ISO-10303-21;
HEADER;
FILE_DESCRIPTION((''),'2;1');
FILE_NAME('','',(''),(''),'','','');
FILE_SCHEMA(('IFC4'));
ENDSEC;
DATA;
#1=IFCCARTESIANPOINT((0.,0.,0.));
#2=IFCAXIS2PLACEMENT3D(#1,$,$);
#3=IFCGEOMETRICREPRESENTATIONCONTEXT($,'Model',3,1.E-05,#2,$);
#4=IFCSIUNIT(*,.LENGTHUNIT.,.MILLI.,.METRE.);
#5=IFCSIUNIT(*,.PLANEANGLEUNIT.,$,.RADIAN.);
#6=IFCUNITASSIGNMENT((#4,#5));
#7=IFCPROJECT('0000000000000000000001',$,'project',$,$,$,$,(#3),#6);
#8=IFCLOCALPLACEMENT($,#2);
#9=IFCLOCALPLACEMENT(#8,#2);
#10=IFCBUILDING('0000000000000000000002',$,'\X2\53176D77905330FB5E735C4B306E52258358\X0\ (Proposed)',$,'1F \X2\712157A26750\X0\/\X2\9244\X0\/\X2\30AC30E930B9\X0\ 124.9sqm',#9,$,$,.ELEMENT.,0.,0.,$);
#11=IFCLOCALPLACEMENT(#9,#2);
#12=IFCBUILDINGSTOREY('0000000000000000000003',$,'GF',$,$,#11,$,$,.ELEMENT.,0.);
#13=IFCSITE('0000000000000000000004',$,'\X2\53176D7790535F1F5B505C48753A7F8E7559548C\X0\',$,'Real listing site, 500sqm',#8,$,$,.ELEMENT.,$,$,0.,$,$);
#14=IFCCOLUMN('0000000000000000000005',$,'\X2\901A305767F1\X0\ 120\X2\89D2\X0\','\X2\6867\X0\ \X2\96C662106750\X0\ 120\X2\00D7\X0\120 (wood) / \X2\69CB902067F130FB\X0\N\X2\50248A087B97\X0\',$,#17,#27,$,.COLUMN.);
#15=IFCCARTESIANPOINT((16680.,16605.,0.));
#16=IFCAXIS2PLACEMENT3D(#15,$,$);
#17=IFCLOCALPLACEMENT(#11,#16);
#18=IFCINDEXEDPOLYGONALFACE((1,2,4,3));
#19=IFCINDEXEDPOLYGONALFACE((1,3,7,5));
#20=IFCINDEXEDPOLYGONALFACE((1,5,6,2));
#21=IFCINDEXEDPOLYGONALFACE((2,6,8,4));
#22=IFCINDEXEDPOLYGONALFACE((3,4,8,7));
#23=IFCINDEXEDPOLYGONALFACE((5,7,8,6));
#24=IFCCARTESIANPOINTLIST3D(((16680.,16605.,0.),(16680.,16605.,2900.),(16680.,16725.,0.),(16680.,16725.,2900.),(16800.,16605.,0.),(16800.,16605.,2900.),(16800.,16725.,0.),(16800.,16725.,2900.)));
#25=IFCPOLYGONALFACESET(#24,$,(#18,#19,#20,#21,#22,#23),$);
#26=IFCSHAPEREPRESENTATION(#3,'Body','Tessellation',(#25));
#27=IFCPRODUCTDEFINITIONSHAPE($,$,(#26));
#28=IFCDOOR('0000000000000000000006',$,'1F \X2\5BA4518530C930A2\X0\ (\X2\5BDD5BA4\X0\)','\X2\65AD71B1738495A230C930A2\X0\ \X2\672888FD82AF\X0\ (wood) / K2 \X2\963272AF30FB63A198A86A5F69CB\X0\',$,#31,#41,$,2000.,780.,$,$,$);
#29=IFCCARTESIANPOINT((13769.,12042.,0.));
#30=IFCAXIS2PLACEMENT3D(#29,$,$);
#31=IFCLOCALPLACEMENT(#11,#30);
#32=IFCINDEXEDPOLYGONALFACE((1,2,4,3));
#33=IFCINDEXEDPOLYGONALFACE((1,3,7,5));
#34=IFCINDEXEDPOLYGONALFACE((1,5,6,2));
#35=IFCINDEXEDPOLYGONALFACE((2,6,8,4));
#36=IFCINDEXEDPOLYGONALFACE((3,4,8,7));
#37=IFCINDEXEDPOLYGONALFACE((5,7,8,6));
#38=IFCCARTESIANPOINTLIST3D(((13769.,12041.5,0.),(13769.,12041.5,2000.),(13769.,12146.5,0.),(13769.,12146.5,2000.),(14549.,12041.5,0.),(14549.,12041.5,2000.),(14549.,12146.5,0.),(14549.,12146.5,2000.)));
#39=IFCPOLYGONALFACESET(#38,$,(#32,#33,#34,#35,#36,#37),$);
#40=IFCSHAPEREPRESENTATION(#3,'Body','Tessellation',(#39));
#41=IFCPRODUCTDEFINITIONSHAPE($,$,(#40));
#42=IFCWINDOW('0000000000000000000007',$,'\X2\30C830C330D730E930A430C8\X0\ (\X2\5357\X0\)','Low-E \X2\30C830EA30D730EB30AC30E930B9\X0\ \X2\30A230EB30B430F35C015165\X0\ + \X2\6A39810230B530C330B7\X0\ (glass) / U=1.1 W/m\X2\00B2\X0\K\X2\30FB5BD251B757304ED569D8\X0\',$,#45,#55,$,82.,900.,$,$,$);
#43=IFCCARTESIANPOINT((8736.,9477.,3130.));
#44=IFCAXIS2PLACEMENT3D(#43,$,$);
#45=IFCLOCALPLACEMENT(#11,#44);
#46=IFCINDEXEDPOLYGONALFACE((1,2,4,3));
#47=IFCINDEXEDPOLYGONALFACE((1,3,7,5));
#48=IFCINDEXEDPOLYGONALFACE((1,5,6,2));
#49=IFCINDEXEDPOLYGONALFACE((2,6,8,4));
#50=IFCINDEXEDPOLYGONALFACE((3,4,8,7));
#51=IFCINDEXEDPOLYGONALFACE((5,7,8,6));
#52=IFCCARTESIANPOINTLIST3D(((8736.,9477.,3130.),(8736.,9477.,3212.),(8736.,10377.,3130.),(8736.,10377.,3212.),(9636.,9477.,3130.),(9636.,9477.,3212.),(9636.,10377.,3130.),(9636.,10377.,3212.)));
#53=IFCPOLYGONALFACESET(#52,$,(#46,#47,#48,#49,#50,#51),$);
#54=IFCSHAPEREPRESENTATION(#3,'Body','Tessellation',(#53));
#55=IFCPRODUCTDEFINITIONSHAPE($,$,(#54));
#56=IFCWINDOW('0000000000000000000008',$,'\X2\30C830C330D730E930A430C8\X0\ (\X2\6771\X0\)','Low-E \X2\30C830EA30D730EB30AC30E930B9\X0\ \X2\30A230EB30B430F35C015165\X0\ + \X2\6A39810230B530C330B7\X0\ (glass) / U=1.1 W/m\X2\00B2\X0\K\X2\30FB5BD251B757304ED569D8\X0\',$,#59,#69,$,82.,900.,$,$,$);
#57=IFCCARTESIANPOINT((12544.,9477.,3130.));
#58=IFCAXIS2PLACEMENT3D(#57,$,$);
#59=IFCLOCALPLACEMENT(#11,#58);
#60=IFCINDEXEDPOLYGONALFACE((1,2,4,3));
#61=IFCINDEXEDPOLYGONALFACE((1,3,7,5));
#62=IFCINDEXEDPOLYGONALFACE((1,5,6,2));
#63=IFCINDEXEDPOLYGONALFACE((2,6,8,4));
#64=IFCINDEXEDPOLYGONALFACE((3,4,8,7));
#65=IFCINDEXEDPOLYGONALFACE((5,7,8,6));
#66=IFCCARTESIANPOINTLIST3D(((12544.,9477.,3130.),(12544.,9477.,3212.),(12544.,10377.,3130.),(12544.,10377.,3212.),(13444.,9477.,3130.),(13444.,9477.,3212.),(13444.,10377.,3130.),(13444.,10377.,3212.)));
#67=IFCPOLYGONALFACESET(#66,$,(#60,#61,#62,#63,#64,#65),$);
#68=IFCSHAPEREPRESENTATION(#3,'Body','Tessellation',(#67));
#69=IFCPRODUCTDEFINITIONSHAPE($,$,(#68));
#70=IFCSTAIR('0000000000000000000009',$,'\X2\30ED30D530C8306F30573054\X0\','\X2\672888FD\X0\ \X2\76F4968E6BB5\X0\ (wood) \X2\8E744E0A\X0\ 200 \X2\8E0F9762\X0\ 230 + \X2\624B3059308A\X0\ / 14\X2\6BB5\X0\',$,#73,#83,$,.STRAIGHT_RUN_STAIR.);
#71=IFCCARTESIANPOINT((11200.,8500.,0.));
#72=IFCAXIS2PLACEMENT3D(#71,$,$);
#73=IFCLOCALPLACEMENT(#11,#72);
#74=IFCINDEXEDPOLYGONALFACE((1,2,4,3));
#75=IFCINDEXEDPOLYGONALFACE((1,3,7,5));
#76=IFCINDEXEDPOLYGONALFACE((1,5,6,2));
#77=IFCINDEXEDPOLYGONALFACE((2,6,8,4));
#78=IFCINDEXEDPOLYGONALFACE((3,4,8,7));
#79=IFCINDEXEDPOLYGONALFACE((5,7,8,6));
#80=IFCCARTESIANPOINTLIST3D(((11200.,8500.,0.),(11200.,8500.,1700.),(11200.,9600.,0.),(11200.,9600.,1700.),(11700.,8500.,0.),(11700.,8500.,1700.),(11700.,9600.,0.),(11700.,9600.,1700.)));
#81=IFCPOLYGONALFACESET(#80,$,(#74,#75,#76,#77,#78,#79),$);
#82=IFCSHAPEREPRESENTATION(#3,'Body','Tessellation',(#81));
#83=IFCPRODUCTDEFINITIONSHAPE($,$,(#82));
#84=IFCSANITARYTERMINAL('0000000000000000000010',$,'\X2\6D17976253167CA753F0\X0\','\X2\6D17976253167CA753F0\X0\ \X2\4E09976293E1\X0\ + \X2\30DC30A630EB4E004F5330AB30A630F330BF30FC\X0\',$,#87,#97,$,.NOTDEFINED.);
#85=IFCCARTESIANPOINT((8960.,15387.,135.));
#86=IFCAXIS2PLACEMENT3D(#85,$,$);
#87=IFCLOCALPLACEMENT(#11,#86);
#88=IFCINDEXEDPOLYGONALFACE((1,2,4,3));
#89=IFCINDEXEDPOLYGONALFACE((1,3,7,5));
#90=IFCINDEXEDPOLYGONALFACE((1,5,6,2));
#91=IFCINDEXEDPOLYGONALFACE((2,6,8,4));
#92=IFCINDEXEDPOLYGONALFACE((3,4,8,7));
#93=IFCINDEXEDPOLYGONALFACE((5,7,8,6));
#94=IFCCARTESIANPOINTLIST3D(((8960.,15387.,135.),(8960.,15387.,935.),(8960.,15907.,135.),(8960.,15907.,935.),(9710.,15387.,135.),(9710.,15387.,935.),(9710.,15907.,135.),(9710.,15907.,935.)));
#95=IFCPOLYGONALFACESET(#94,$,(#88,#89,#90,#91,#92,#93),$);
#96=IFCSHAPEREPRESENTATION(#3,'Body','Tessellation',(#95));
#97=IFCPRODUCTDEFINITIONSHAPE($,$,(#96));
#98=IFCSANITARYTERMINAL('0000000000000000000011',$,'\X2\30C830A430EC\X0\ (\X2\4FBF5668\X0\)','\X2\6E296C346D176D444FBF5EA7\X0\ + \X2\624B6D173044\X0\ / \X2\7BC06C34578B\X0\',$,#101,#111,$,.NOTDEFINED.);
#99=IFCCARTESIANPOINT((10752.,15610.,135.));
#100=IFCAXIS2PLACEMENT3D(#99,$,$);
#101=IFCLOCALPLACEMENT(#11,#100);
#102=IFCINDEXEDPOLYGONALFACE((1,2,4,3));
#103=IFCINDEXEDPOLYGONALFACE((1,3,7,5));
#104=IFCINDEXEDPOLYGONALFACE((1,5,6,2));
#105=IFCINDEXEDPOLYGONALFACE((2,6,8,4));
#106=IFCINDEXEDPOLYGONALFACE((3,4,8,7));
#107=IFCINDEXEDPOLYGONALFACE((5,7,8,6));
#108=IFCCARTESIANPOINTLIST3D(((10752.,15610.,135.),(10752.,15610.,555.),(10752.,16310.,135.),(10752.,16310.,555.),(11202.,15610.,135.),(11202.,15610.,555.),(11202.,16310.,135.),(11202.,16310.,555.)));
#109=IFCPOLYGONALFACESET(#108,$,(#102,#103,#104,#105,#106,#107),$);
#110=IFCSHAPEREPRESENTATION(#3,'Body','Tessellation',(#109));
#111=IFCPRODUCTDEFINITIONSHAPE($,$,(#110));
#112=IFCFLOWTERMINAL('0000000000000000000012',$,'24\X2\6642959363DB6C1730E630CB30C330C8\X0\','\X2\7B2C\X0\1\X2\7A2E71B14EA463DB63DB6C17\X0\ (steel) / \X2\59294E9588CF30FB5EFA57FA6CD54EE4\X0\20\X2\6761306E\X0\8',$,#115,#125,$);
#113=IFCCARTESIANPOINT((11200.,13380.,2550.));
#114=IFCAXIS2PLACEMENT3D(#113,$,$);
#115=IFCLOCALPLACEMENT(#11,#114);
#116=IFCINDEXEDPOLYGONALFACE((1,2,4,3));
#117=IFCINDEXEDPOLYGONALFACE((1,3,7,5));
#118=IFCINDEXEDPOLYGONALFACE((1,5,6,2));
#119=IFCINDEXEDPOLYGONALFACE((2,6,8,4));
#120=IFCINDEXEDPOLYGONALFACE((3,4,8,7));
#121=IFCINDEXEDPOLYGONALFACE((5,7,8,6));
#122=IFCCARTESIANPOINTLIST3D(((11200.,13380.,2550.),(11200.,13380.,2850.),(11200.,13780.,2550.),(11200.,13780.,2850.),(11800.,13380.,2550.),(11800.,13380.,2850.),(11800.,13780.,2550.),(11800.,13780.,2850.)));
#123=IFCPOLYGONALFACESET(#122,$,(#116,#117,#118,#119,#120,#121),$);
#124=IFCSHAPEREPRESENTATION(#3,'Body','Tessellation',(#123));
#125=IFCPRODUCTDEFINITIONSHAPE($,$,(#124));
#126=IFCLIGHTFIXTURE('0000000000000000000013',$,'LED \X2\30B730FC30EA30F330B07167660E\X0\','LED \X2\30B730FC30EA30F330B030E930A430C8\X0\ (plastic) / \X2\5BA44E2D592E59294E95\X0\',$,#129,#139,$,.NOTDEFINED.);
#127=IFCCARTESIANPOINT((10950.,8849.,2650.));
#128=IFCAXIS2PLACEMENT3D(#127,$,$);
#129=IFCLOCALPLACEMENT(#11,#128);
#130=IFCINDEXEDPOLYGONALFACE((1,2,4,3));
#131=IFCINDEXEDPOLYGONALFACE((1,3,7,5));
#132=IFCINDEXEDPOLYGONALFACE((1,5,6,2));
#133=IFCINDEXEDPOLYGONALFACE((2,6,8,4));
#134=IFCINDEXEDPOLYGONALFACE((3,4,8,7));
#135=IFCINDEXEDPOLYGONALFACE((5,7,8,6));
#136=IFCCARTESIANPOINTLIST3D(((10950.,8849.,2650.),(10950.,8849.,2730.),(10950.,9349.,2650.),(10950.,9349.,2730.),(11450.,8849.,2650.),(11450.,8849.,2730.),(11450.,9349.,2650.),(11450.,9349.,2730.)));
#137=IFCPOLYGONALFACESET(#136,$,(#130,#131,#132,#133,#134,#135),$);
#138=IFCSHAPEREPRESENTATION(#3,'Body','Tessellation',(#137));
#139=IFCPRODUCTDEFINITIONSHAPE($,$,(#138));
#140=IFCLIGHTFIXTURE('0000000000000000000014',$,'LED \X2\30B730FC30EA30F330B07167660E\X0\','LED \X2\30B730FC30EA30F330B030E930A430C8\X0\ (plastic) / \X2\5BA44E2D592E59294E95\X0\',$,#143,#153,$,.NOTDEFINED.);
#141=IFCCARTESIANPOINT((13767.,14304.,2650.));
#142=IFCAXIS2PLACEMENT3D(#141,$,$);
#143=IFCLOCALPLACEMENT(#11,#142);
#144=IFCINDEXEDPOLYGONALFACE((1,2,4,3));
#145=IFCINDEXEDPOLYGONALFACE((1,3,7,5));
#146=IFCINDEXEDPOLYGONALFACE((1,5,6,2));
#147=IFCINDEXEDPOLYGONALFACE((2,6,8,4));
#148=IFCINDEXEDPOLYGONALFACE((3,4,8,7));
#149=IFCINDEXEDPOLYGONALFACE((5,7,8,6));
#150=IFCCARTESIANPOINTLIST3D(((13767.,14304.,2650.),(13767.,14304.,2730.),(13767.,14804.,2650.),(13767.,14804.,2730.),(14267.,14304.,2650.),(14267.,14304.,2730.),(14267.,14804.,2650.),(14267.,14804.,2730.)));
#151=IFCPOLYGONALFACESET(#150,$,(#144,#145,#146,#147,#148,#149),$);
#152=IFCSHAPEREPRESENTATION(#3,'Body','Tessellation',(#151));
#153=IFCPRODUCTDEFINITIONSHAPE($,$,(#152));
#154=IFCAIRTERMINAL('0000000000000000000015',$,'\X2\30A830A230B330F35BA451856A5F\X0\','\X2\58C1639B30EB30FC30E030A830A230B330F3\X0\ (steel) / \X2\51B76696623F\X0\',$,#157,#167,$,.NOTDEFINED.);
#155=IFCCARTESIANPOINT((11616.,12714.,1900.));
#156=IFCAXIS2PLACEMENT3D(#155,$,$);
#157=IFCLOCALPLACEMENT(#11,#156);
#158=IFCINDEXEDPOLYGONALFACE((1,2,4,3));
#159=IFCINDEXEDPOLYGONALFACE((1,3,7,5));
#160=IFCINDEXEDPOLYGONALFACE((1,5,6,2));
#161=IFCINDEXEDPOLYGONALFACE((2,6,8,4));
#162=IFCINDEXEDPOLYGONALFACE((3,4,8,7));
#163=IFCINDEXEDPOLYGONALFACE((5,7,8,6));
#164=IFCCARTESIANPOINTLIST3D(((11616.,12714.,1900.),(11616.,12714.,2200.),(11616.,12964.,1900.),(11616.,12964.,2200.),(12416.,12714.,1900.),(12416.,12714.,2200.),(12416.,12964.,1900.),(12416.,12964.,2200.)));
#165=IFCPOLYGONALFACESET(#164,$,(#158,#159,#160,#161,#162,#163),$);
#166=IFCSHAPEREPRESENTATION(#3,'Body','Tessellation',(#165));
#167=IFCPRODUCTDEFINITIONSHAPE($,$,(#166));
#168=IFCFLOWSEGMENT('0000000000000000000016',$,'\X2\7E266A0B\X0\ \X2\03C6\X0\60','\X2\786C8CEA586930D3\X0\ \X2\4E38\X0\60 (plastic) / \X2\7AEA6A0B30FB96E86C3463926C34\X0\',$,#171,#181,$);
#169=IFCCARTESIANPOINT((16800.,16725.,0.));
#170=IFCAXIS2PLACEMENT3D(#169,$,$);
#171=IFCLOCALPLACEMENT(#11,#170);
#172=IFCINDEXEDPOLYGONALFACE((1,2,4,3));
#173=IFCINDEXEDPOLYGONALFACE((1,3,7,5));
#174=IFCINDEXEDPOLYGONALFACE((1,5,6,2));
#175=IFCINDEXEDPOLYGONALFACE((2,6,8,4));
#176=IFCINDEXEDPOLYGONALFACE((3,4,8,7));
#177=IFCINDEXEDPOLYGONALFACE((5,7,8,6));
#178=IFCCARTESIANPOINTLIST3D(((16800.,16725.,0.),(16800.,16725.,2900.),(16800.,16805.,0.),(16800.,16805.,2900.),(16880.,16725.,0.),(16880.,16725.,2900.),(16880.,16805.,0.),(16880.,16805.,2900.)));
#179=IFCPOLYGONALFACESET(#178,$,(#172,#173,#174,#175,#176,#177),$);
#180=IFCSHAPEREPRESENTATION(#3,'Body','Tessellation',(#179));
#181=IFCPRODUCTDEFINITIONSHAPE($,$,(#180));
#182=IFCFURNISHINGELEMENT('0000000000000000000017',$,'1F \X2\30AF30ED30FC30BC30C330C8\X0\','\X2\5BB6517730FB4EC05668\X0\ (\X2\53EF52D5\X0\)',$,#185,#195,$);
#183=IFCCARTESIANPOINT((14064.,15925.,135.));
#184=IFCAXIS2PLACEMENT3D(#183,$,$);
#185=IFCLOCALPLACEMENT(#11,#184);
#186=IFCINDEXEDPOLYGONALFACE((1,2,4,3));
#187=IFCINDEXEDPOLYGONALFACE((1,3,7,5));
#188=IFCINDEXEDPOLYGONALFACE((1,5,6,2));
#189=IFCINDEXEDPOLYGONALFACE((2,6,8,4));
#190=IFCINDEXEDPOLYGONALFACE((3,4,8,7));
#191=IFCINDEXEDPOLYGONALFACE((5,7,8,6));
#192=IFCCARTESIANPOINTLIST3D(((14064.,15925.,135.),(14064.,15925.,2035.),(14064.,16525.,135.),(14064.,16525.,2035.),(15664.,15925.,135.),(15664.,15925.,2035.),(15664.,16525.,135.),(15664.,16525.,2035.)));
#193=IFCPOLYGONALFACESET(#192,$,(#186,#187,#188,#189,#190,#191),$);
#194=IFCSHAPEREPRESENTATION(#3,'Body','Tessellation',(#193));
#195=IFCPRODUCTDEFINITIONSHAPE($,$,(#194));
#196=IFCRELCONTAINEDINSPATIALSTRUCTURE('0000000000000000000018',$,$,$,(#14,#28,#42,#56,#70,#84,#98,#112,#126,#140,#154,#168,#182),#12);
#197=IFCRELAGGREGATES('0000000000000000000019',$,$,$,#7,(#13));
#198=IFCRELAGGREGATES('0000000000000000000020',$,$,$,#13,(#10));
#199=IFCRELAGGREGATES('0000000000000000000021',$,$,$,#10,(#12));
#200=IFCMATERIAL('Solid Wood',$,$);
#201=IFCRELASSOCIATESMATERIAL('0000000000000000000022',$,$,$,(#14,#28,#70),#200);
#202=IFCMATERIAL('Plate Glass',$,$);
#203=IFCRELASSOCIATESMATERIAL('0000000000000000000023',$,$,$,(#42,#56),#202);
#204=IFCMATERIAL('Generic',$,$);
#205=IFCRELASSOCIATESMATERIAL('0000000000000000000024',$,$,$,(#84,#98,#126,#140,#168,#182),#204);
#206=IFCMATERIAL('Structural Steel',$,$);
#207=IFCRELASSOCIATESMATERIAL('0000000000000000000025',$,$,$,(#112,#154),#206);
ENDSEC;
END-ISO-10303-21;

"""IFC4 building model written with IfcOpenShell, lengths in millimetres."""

from ifc_helpers import new_model, si_unit, frame, frame_2d, origin, place, context, project, spatial, rectangle, extrude, material, element, save


model = new_model("IFC4")

# Units and contexts
model_context = context("Model", 3, precision=1e-05, world=origin())
ifc_project = project(units=[si_unit("LENGTHUNIT", "METRE", prefix="MILLI"), si_unit("PLANEANGLEUNIT", "RADIAN")], contexts=[model_context])

# Site, building, storey
site_placement = place(None, origin())
site = spatial("IfcSite", under=ifc_project, at=site_placement, Name="北海道弟子屈町美留和", ObjectType="Real listing site, 500sqm", CompositionType="ELEMENT", RefElevation=0.0)
building_placement = place(site_placement, origin())
building = spatial("IfcBuilding", under=site, at=building_placement, Name="北海道・平屋の別荘 (Proposed)", ObjectType="1F 無垢材/鉄/ガラス 124.9sqm", CompositionType="ELEMENT", ElevationOfRefHeight=0.0, ElevationOfTerrain=0.0)
storey_placement = place(building_placement, origin())
storey = spatial("IfcBuildingStorey", under=building, at=storey_placement, Name="GF", CompositionType="ELEMENT", Elevation=0.0)

# Column
ifc_material_1 = material(Name="Solid Wood")
column_1_placement = place(storey_placement, frame((16680.0, 16605.0, 0.0)))
element("IfcColumn", 1, at=column_1_placement, inside=storey, material=ifc_material_1, Name="通し柱 120角", Description="桧 集成材 120×120 (wood) / 構造柱・N値計算", PredefinedType="COLUMN", context=model_context, shape_type="SweptSolid", body=[
    extrude(rectangle(XDim=120.0, YDim=120.0, at=frame_2d((60.0, 60.0))), frame((16680.0, 16605.0, 0.0)), (0.0, 0.0, 1.0), 2900.0),
])

# Door
door_placement = place(storey_placement, frame((13769.0, 12042.0, 0.0)))
element("IfcDoor", 2, at=door_placement, inside=storey, material=ifc_material_1, Name="1F 室内ドア (寝室)", Description="断熱玄関ドア 木製芯 (wood) / K2 防犯・採風機構", OverallHeight=2000.0, OverallWidth=780.0, context=model_context, shape_type="SweptSolid", body=[
    extrude(rectangle(XDim=780.0, YDim=105.0, at=frame_2d((390.0, 52.0))), frame((13769.0, 12042.0, 0.0)), (0.0, 0.0, 1.0), 2000.0),
])

# Windows
ifc_material_2 = material(Name="Plate Glass")
window_1_placement = place(storey_placement, frame((8736.0, 9477.0, 3130.0)))
element("IfcWindow", 3, at=window_1_placement, inside=storey, material=ifc_material_2, Name="トップライト (南)", Description="Low-E トリプルガラス アルゴン封入 + 樹脂サッシ (glass) / U=1.1 W/m²K・寒冷地仕様", OverallHeight=82.0, OverallWidth=900.0, context=model_context, shape_type="SweptSolid", body=[
    extrude(rectangle(XDim=900.0, YDim=900.0, at=frame_2d((450.0, 450.0))), frame((8736.0, 9477.0, 3130.0)), (0.0, 0.0, 1.0), 82.0),
])
window_2_placement = place(storey_placement, frame((12544.0, 9477.0, 3130.0)))
element("IfcWindow", 4, at=window_2_placement, inside=storey, material=ifc_material_2, Name="トップライト (東)", Description="Low-E トリプルガラス アルゴン封入 + 樹脂サッシ (glass) / U=1.1 W/m²K・寒冷地仕様", OverallHeight=82.0, OverallWidth=900.0, context=model_context, shape_type="SweptSolid", body=[
    extrude(rectangle(XDim=900.0, YDim=900.0, at=frame_2d((450.0, 450.0))), frame((12544.0, 9477.0, 3130.0)), (0.0, 0.0, 1.0), 82.0),
])

# Stair
stair_placement = place(storey_placement, frame((11200.0, 8500.0, 0.0)))
element("IfcStair", 5, at=stair_placement, inside=storey, material=ifc_material_1, Name="ロフトはしご", Description="木製 直階段 (wood) 蹴上 200 踏面 230 + 手すり / 14段", PredefinedType="STRAIGHT_RUN_STAIR", context=model_context, shape_type="SweptSolid", body=[
    extrude(rectangle(XDim=500.0, YDim=1100.0, at=frame_2d((250.0, 550.0))), frame((11200.0, 8500.0, 0.0)), (0.0, 0.0, 1.0), 1700.0),
])

# Sanitary terminals
ifc_material_3 = material(Name="Generic")
sanitary_terminal_1_placement = place(storey_placement, frame((8960.0, 15387.0, 135.0)))
element("IfcSanitaryTerminal", 6, at=sanitary_terminal_1_placement, inside=storey, material=ifc_material_3, Name="洗面化粧台", Description="洗面化粧台 三面鏡 + ボウル一体カウンター", PredefinedType="NOTDEFINED", context=model_context, shape_type="SweptSolid", body=[
    extrude(rectangle(XDim=750.0, YDim=520.0, at=frame_2d((375.0, 260.0))), frame((8960.0, 15387.0, 135.0)), (0.0, 0.0, 1.0), 800.0),
])
sanitary_terminal_2_placement = place(storey_placement, frame((10752.0, 15610.0, 135.0)))
element("IfcSanitaryTerminal", 7, at=sanitary_terminal_2_placement, inside=storey, material=ifc_material_3, Name="トイレ (便器)", Description="温水洗浄便座 + 手洗い / 節水型", PredefinedType="NOTDEFINED", context=model_context, shape_type="SweptSolid", body=[
    extrude(rectangle(XDim=450.0, YDim=700.0, at=frame_2d((225.0, 350.0))), frame((10752.0, 15610.0, 135.0)), (0.0, 0.0, 1.0), 420.0),
])

# Flow terminal
ifc_material_4 = material(Name="Structural Steel")
flow_terminal_placement = place(storey_placement, frame((11200.0, 13380.0, 2550.0)))
element("IfcFlowTerminal", 8, at=flow_terminal_placement, inside=storey, material=ifc_material_4, Name="24時間換気ユニット", Description="第1種熱交換換気 (steel) / 天井裏・建基法令20条の8", context=model_context, shape_type="SweptSolid", body=[
    extrude(rectangle(XDim=600.0, YDim=400.0, at=frame_2d((300.0, 200.0))), frame((11200.0, 13380.0, 2550.0)), (0.0, 0.0, 1.0), 300.0),
])

# Light fixtures
light_fixture_1_placement = place(storey_placement, frame((10950.0, 8849.0, 2650.0)))
element("IfcLightFixture", 9, at=light_fixture_1_placement, inside=storey, material=ifc_material_3, Name="LED シーリング照明", Description="LED シーリングライト (plastic) / 室中央天井", PredefinedType="NOTDEFINED", context=model_context, shape_type="SweptSolid", body=[
    extrude(rectangle(XDim=500.0, YDim=500.0, at=frame_2d((250.0, 250.0))), frame((10950.0, 8849.0, 2650.0)), (0.0, 0.0, 1.0), 80.0),
])
light_fixture_2_placement = place(storey_placement, frame((13767.0, 14304.0, 2650.0)))
element("IfcLightFixture", 10, at=light_fixture_2_placement, inside=storey, material=ifc_material_3, Name="LED シーリング照明", Description="LED シーリングライト (plastic) / 室中央天井", PredefinedType="NOTDEFINED", context=model_context, shape_type="SweptSolid", body=[
    extrude(rectangle(XDim=500.0, YDim=500.0, at=frame_2d((250.0, 250.0))), frame((13767.0, 14304.0, 2650.0)), (0.0, 0.0, 1.0), 80.0),
])

# Air terminal
air_terminal_placement = place(storey_placement, frame((11616.0, 12714.0, 1900.0)))
element("IfcAirTerminal", 11, at=air_terminal_placement, inside=storey, material=ifc_material_4, Name="エアコン室内機", Description="壁掛ルームエアコン (steel) / 冷暖房", PredefinedType="NOTDEFINED", context=model_context, shape_type="SweptSolid", body=[
    extrude(rectangle(XDim=800.0, YDim=250.0, at=frame_2d((400.0, 125.0))), frame((11616.0, 12714.0, 1900.0)), (0.0, 0.0, 1.0), 300.0),
])

# Flow segment
flow_segment_placement = place(storey_placement, frame((16800.0, 16725.0, 0.0)))
element("IfcFlowSegment", 12, at=flow_segment_placement, inside=storey, material=ifc_material_3, Name="縦樋 φ60", Description="硬質塩ビ 丸60 (plastic) / 竪樋・雨水排水", context=model_context, shape_type="SweptSolid", body=[
    extrude(rectangle(XDim=80.0, YDim=80.0, at=frame_2d((40.0, 40.0))), frame((16800.0, 16725.0, 0.0)), (0.0, 0.0, 1.0), 2900.0),
])

# Furnishing element
furnishing_placement = place(storey_placement, frame((14064.0, 15925.0, 135.0)))
element("IfcFurnishingElement", 13, at=furnishing_placement, inside=storey, material=ifc_material_3, Name="1F クローゼット", Description="家具・什器 (可動)", context=model_context, shape_type="SweptSolid", body=[
    extrude(rectangle(XDim=1600.0, YDim=600.0, at=frame_2d((800.0, 300.0))), frame((14064.0, 15925.0, 135.0)), (0.0, 0.0, 1.0), 1900.0),
])

save(model, "model.ifc")
